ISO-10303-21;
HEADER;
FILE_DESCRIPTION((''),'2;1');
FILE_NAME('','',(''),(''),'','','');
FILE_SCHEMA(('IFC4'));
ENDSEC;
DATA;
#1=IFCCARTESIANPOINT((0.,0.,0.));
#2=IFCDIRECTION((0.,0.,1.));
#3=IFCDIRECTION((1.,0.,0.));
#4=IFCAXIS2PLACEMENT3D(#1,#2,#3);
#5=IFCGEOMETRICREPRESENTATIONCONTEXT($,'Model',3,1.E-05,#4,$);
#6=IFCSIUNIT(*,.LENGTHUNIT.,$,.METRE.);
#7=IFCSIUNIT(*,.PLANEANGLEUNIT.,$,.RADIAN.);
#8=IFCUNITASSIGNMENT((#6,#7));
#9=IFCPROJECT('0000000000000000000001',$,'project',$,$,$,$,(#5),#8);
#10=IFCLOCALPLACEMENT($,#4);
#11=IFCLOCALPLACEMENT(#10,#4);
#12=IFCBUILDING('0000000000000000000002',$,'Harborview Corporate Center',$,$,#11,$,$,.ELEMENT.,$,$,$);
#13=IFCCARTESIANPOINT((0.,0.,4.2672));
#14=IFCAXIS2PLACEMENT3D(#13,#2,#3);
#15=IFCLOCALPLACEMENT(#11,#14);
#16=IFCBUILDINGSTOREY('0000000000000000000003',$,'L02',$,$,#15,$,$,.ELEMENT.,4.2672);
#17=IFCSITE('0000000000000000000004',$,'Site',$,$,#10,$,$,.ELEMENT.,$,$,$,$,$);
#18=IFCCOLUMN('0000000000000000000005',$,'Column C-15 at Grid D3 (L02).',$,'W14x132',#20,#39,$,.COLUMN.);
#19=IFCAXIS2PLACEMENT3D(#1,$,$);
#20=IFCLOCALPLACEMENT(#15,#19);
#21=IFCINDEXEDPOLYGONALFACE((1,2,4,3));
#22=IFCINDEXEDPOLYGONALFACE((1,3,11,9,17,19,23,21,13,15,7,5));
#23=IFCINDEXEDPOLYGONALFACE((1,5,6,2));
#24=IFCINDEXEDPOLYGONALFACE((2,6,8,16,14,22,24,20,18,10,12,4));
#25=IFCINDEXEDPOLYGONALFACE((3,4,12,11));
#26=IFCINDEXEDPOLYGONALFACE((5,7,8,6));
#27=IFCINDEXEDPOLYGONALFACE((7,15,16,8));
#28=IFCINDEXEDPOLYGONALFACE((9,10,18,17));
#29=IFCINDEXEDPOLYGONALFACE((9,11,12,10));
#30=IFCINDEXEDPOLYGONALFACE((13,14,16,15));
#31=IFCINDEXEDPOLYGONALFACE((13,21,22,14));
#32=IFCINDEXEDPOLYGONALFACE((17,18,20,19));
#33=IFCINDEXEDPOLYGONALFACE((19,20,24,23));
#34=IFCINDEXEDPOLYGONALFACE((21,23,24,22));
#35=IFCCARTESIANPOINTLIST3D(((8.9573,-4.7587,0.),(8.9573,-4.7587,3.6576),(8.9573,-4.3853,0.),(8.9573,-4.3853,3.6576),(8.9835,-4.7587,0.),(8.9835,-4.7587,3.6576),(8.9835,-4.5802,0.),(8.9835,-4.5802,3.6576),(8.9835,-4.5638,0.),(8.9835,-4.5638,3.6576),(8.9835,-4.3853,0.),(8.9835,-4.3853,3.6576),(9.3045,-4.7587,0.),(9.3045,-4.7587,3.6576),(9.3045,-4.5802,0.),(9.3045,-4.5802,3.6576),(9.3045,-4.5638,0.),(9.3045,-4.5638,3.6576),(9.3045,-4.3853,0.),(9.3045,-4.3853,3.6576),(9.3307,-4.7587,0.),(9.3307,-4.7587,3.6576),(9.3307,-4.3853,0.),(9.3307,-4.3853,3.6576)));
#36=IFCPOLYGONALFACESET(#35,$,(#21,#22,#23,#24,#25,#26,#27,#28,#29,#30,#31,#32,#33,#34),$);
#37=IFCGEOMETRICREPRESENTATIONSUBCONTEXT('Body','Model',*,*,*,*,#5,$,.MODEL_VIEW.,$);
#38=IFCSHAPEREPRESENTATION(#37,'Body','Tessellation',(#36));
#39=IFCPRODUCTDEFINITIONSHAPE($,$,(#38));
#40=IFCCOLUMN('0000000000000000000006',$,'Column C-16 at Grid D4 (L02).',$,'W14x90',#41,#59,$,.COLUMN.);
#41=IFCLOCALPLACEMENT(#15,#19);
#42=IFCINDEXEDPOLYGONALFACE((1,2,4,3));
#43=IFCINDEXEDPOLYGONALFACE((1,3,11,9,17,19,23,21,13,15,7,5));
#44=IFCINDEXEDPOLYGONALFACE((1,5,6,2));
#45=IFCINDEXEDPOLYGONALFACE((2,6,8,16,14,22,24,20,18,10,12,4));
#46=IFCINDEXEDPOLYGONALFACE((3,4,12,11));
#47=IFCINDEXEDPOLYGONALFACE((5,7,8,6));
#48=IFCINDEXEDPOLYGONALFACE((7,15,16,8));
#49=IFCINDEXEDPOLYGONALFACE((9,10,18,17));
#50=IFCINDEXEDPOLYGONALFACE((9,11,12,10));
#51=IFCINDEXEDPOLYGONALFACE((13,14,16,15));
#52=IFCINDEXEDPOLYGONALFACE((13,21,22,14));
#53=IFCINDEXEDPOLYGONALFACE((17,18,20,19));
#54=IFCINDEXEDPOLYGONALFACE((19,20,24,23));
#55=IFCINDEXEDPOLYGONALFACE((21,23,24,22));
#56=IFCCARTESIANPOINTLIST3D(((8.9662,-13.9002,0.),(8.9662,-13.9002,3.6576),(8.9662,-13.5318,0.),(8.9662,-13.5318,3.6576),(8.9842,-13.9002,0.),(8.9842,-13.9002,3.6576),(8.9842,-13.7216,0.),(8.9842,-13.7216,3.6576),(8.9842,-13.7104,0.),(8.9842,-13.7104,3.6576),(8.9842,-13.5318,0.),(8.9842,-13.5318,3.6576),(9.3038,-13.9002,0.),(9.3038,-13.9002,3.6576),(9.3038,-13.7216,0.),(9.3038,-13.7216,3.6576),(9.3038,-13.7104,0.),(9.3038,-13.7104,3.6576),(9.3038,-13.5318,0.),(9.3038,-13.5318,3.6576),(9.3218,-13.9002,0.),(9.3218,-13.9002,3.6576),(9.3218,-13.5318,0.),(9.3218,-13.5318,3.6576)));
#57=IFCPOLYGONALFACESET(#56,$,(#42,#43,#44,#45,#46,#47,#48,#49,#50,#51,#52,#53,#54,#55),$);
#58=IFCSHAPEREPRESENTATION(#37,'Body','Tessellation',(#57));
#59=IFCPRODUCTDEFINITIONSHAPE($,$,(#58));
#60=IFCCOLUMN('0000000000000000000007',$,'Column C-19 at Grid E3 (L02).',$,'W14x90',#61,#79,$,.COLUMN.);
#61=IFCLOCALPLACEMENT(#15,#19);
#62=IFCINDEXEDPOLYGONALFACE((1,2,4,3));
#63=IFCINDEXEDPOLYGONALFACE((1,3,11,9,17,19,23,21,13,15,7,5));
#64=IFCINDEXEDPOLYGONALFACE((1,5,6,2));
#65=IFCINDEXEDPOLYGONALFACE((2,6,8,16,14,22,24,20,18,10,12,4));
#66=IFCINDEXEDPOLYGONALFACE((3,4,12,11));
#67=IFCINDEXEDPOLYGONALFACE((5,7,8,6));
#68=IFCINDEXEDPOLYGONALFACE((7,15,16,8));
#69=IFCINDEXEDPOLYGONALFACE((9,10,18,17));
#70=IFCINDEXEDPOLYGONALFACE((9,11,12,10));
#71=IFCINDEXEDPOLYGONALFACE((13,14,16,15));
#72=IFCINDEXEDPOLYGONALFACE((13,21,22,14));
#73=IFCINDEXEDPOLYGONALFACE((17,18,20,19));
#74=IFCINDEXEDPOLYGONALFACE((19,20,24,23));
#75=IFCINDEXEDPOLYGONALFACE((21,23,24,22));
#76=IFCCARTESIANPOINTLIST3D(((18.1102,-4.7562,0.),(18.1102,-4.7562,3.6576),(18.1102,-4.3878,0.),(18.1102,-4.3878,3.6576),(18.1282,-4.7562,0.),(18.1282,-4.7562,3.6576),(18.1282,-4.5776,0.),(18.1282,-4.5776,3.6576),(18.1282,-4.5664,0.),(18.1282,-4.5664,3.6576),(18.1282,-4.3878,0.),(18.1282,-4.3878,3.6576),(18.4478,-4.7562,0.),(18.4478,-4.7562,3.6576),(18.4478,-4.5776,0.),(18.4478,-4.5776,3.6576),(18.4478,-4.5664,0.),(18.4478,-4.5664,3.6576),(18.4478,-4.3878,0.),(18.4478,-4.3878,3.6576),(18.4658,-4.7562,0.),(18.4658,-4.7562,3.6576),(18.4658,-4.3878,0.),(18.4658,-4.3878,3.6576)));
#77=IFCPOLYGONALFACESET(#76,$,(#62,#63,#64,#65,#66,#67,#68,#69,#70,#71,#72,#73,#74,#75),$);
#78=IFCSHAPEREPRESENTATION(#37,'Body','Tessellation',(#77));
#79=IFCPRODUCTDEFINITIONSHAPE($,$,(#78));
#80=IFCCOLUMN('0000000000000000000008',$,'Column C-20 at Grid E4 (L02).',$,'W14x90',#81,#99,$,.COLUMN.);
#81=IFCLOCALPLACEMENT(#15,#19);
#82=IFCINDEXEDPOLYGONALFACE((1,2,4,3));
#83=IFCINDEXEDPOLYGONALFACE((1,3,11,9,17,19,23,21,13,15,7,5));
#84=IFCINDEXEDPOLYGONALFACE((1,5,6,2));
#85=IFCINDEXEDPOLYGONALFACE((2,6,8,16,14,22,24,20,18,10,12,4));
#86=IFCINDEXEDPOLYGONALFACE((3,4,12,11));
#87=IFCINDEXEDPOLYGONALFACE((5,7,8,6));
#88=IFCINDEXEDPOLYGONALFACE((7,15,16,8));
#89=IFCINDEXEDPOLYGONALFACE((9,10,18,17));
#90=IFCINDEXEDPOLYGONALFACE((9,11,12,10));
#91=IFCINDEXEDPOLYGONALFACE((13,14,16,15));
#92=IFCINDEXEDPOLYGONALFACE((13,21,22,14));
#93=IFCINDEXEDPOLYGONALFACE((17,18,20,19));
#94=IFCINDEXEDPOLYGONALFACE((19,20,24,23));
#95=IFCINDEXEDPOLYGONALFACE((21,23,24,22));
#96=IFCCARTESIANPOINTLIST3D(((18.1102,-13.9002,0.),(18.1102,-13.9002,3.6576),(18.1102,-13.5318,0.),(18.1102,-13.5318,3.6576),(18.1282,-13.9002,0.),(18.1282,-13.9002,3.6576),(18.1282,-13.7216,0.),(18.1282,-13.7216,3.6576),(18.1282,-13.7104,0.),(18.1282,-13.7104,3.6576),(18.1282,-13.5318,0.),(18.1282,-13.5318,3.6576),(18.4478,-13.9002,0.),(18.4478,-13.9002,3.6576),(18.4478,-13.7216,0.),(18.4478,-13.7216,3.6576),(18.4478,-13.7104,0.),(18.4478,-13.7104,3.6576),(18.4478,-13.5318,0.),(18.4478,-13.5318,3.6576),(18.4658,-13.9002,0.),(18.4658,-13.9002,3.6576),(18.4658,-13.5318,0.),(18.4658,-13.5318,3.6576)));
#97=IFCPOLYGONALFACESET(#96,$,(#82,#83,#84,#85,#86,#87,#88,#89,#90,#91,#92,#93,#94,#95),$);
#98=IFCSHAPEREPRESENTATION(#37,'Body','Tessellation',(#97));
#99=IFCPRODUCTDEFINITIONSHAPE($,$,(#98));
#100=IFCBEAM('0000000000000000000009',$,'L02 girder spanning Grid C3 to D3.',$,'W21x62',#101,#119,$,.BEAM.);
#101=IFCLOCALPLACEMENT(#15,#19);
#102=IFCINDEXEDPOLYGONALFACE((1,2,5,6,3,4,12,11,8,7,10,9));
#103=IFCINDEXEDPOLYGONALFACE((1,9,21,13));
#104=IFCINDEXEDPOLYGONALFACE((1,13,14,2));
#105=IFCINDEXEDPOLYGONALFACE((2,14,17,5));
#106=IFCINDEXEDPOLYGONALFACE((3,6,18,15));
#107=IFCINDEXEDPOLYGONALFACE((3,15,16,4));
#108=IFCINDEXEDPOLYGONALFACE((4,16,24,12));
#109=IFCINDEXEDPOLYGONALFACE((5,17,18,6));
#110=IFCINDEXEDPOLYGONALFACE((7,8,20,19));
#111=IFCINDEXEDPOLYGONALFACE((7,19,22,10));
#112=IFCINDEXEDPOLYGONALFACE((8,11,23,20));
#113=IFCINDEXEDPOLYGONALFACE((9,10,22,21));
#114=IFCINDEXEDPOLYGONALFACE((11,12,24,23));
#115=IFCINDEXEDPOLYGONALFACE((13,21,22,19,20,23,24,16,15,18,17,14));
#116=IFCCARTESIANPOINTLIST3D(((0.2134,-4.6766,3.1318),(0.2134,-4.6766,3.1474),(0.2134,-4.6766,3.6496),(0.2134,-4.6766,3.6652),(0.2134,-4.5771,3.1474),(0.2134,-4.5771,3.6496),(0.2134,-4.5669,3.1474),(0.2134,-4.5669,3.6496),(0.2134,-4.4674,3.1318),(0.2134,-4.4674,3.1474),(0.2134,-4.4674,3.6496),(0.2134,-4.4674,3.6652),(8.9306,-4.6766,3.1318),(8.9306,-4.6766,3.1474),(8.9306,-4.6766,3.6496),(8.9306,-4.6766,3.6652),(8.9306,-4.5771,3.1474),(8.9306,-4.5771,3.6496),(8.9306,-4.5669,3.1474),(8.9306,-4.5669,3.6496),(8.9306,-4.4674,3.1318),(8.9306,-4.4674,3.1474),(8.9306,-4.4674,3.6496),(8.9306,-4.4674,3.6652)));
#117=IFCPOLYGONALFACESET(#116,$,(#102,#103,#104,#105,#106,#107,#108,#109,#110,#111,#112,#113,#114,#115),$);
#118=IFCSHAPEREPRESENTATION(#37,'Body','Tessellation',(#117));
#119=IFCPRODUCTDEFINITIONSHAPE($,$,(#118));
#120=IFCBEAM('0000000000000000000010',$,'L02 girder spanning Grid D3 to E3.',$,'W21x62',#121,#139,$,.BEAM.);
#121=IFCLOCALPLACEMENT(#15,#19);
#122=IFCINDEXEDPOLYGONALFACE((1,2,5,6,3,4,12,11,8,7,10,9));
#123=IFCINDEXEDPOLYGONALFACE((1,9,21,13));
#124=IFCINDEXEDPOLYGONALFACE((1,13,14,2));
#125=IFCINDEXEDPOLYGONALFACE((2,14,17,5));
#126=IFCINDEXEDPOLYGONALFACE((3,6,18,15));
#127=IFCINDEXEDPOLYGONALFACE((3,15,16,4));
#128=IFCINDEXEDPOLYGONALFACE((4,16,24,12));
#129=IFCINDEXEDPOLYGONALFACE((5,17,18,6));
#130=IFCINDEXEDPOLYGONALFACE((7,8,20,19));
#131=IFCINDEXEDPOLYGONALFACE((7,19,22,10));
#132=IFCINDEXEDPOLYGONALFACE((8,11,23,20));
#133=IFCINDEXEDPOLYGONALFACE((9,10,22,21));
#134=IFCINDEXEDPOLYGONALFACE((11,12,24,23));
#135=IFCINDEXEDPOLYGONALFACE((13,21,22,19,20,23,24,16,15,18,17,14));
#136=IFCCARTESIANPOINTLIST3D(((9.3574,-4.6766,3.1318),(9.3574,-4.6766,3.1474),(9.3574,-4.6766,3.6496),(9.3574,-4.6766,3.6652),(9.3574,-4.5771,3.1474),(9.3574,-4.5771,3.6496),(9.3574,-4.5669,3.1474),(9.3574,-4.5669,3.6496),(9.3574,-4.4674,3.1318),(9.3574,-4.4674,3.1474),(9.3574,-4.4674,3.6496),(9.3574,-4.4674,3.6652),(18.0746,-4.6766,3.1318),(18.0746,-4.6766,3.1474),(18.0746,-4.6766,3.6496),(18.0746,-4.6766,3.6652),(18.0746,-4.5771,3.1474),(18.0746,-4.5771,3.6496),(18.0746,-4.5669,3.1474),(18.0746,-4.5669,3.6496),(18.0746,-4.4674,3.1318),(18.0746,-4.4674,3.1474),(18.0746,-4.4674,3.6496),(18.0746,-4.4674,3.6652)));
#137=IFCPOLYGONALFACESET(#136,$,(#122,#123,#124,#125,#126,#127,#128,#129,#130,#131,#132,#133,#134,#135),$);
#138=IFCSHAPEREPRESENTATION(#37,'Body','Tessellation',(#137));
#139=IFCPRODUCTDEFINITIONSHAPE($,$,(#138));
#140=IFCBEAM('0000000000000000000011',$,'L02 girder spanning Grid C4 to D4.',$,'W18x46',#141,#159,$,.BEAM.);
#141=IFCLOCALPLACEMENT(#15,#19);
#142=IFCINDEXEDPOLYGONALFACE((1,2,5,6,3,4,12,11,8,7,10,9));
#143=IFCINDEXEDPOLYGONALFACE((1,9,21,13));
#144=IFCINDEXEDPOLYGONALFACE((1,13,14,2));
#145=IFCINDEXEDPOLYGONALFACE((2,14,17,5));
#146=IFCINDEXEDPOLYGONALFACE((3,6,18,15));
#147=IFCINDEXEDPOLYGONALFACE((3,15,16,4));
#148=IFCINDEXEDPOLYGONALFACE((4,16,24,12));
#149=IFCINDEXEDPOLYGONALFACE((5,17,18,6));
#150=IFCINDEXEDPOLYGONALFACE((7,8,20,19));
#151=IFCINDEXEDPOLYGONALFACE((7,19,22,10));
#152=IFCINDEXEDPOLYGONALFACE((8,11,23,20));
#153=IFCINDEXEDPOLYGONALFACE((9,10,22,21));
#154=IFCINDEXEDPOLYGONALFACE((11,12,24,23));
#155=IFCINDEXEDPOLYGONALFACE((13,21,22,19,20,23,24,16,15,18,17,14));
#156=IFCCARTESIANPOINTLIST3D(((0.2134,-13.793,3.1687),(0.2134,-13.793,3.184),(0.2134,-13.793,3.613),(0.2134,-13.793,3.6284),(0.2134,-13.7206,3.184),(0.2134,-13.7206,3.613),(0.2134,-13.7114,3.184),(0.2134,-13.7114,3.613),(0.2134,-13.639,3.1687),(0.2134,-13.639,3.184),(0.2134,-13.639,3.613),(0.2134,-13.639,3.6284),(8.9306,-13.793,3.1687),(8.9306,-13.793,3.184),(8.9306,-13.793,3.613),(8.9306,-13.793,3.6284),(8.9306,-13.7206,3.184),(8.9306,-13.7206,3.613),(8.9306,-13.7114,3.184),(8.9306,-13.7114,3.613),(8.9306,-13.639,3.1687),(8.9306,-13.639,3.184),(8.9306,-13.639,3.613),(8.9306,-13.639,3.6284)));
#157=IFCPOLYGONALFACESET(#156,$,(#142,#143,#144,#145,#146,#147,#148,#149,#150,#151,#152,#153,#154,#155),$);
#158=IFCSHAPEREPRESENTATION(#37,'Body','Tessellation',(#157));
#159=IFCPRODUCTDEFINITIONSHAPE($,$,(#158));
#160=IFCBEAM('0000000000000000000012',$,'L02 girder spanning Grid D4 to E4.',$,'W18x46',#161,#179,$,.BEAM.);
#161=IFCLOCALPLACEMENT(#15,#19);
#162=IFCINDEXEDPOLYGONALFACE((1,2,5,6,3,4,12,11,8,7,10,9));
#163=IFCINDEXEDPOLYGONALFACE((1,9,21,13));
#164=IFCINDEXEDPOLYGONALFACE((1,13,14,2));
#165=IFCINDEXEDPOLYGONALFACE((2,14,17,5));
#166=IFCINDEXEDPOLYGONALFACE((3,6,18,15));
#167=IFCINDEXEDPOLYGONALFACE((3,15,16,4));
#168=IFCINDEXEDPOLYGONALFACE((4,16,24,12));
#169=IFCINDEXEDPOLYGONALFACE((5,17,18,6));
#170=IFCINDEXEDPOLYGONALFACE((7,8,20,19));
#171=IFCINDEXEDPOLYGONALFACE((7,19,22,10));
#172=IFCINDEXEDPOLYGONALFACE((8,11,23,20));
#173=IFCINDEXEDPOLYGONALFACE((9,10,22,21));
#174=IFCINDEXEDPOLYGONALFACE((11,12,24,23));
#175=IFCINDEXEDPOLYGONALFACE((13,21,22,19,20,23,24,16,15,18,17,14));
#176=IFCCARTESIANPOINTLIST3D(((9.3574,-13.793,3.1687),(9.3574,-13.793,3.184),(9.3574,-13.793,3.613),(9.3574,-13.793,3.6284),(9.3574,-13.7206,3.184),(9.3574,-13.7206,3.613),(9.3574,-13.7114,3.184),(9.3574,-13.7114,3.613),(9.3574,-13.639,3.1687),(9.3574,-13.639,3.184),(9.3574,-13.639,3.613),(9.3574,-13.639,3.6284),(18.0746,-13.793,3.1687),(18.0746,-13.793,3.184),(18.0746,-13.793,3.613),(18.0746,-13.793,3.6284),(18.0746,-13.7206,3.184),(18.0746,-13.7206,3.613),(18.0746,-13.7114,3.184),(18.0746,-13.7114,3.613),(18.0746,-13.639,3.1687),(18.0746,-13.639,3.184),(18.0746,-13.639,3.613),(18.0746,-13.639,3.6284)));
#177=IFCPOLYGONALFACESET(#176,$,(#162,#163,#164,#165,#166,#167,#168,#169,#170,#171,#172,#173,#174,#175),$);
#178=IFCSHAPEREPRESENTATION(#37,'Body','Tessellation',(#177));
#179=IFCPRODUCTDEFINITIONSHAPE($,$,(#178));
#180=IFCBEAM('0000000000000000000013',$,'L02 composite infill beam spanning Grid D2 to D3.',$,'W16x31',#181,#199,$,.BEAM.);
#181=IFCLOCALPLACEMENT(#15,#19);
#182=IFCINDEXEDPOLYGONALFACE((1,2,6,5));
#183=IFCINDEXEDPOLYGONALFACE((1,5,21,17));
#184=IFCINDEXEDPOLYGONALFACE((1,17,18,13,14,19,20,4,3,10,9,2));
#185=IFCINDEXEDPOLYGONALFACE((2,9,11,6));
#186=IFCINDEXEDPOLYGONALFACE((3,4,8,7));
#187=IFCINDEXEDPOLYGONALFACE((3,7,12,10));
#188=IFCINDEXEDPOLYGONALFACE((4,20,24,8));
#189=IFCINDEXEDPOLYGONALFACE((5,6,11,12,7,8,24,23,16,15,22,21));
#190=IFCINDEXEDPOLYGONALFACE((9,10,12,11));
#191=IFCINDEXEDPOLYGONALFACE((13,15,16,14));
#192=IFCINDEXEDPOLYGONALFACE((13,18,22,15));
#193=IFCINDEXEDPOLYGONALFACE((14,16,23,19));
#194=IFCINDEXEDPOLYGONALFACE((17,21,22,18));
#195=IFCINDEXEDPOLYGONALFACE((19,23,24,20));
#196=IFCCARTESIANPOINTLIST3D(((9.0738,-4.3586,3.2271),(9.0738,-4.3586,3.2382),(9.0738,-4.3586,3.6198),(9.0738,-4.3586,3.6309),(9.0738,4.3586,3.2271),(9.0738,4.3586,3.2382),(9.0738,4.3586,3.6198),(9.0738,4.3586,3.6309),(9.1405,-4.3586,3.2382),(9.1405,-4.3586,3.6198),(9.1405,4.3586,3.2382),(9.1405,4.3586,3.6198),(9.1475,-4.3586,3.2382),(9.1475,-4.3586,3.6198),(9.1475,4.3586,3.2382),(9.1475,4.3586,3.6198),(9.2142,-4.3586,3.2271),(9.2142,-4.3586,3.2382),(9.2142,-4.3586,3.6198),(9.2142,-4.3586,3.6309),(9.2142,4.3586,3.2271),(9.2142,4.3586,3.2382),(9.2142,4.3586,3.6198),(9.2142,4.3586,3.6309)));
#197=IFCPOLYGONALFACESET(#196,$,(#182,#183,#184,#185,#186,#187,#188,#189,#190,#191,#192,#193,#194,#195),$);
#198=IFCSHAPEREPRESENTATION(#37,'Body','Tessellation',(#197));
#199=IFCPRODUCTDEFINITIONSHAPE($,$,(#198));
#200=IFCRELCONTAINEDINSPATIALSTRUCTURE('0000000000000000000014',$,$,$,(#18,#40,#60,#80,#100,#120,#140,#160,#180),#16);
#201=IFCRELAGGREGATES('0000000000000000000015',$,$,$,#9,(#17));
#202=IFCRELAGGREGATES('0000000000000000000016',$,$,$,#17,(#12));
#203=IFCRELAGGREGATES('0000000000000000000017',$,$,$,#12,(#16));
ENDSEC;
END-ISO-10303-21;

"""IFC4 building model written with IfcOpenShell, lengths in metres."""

from ifc_helpers import new_model, si_unit, frame, origin_with_axes, place, context, subcontext, project, spatial, i_section, extrude, element, save


model = new_model("IFC4")

# Units and contexts
model_context = context("Model", 3, precision=1e-05, world=origin_with_axes())
body_context = subcontext(model_context, "Body", "Model", "MODEL_VIEW")
ifc_project = project(units=[si_unit("LENGTHUNIT", "METRE"), si_unit("PLANEANGLEUNIT", "RADIAN")], contexts=[model_context])

# Site, building, storey
site_placement = place(None, origin_with_axes())
site = spatial("IfcSite", under=ifc_project, at=site_placement, Name="Site", CompositionType="ELEMENT")
building_placement = place(site_placement, origin_with_axes())
building = spatial("IfcBuilding", under=site, at=building_placement, Name="Harborview Corporate Center", CompositionType="ELEMENT")
storey_placement = place(building_placement, frame((0.0, 0.0, 4.2672), z_axis=(0.0, 0.0, 1.0), x_axis=(1.0, 0.0, 0.0)))
storey = spatial("IfcBuildingStorey", under=building, at=storey_placement, Name="L02", CompositionType="ELEMENT", Elevation=4.2672)

# Columns
column_placement = place(storey_placement, frame((9.144, -4.572, 0.0), z_axis=(0.0, 0.0, 1.0), x_axis=(0.0, 1.0, 0.0)))
element("IfcColumn", 1, at=column_placement, inside=storey, Name="Column C-15 at Grid D3 (L02).", ObjectType="W14x132", PredefinedType="COLUMN", context=body_context, shape_type="SweptSolid", body=[
    extrude(i_section(OverallWidth=0.3734, OverallDepth=0.3734, WebThickness=0.0164, FlangeThickness=0.0262), origin_with_axes(), (0.0, 0.0, 1.0), 3.6576),
])
for number, where, z_axis, x_axis, name in (
    (2, (9.144, -13.716, 0.0), (0.0, 0.0, 1.0), (0.0, 1.0, 0.0), "Column C-16 at Grid D4 (L02)."),
    (3, (18.288, -4.572, 0.0), (0.0, 0.0, 1.0), (0.0, 1.0, 0.0), "Column C-19 at Grid E3 (L02)."),
    (4, (18.288, -13.716, 0.0), (0.0, 0.0, 1.0), (0.0, 1.0, 0.0), "Column C-20 at Grid E4 (L02)."),
):
    element("IfcColumn", number, at=place(storey_placement, frame(where, z_axis=z_axis, x_axis=x_axis)), inside=storey, Name=name, ObjectType="W14x90", PredefinedType="COLUMN", context=body_context, shape_type="SweptSolid", body=[
        extrude(i_section(OverallWidth=0.3683, OverallDepth=0.3556, WebThickness=0.0112, FlangeThickness=0.018), origin_with_axes(), (0.0, 0.0, 1.0), 3.6576),
    ])

# Beams
beam_1_placement = place(storey_placement, frame((0.2134, -4.572, 3.3985), z_axis=(1.0, 0.0, 0.0), x_axis=(0.0, 1.0, 0.0)))
element("IfcBeam", 5, at=beam_1_placement, inside=storey, Name="L02 girder spanning Grid C3 to D3.", ObjectType="W21x62", PredefinedType="BEAM", context=body_context, shape_type="SweptSolid", body=[
    extrude(i_section(OverallWidth=0.2093, OverallDepth=0.5334, WebThickness=0.0102, FlangeThickness=0.0156), origin_with_axes(), (0.0, 0.0, 1.0), 8.7173),
])
beam_2_placement = place(storey_placement, frame((9.3574, -4.572, 3.3985), z_axis=(1.0, 0.0, 0.0), x_axis=(0.0, 1.0, 0.0)))
element("IfcBeam", 6, at=beam_2_placement, inside=storey, Name="L02 girder spanning Grid D3 to E3.", ObjectType="W21x62", PredefinedType="BEAM", context=body_context, shape_type="SweptSolid", body=[
    extrude(i_section(OverallWidth=0.2093, OverallDepth=0.5334, WebThickness=0.0102, FlangeThickness=0.0156), origin_with_axes(), (0.0, 0.0, 1.0), 8.7173),
])
beam_3_placement = place(storey_placement, frame((0.2134, -13.716, 3.3985), z_axis=(1.0, 0.0, 0.0), x_axis=(0.0, 1.0, 0.0)))
element("IfcBeam", 7, at=beam_3_placement, inside=storey, Name="L02 girder spanning Grid C4 to D4.", ObjectType="W18x46", PredefinedType="BEAM", context=body_context, shape_type="SweptSolid", body=[
    extrude(i_section(OverallWidth=0.1539, OverallDepth=0.4597, WebThickness=0.0091, FlangeThickness=0.0154), origin_with_axes(), (0.0, 0.0, 1.0), 8.7173),
])
beam_4_placement = place(storey_placement, frame((9.3574, -13.716, 3.3985), z_axis=(1.0, 0.0, 0.0), x_axis=(0.0, 1.0, 0.0)))
element("IfcBeam", 8, at=beam_4_placement, inside=storey, Name="L02 girder spanning Grid D4 to E4.", ObjectType="W18x46", PredefinedType="BEAM", context=body_context, shape_type="SweptSolid", body=[
    extrude(i_section(OverallWidth=0.1539, OverallDepth=0.4597, WebThickness=0.0091, FlangeThickness=0.0154), origin_with_axes(), (0.0, 0.0, 1.0), 8.7173),
])
beam_5_placement = place(storey_placement, frame((9.144, -4.3586, 3.429), z_axis=(0.0, 1.0, 0.0), x_axis=(-1.0, 0.0, 0.0)))
element("IfcBeam", 9, at=beam_5_placement, inside=storey, Name="L02 composite infill beam spanning Grid D2 to D3.", ObjectType="W16x31", PredefinedType="BEAM", context=body_context, shape_type="SweptSolid", body=[
    extrude(i_section(OverallWidth=0.1405, OverallDepth=0.4039, WebThickness=0.007, FlangeThickness=0.0112), origin_with_axes(), (0.0, 0.0, 1.0), 8.7173),
])

save(model, "model.ifc")
